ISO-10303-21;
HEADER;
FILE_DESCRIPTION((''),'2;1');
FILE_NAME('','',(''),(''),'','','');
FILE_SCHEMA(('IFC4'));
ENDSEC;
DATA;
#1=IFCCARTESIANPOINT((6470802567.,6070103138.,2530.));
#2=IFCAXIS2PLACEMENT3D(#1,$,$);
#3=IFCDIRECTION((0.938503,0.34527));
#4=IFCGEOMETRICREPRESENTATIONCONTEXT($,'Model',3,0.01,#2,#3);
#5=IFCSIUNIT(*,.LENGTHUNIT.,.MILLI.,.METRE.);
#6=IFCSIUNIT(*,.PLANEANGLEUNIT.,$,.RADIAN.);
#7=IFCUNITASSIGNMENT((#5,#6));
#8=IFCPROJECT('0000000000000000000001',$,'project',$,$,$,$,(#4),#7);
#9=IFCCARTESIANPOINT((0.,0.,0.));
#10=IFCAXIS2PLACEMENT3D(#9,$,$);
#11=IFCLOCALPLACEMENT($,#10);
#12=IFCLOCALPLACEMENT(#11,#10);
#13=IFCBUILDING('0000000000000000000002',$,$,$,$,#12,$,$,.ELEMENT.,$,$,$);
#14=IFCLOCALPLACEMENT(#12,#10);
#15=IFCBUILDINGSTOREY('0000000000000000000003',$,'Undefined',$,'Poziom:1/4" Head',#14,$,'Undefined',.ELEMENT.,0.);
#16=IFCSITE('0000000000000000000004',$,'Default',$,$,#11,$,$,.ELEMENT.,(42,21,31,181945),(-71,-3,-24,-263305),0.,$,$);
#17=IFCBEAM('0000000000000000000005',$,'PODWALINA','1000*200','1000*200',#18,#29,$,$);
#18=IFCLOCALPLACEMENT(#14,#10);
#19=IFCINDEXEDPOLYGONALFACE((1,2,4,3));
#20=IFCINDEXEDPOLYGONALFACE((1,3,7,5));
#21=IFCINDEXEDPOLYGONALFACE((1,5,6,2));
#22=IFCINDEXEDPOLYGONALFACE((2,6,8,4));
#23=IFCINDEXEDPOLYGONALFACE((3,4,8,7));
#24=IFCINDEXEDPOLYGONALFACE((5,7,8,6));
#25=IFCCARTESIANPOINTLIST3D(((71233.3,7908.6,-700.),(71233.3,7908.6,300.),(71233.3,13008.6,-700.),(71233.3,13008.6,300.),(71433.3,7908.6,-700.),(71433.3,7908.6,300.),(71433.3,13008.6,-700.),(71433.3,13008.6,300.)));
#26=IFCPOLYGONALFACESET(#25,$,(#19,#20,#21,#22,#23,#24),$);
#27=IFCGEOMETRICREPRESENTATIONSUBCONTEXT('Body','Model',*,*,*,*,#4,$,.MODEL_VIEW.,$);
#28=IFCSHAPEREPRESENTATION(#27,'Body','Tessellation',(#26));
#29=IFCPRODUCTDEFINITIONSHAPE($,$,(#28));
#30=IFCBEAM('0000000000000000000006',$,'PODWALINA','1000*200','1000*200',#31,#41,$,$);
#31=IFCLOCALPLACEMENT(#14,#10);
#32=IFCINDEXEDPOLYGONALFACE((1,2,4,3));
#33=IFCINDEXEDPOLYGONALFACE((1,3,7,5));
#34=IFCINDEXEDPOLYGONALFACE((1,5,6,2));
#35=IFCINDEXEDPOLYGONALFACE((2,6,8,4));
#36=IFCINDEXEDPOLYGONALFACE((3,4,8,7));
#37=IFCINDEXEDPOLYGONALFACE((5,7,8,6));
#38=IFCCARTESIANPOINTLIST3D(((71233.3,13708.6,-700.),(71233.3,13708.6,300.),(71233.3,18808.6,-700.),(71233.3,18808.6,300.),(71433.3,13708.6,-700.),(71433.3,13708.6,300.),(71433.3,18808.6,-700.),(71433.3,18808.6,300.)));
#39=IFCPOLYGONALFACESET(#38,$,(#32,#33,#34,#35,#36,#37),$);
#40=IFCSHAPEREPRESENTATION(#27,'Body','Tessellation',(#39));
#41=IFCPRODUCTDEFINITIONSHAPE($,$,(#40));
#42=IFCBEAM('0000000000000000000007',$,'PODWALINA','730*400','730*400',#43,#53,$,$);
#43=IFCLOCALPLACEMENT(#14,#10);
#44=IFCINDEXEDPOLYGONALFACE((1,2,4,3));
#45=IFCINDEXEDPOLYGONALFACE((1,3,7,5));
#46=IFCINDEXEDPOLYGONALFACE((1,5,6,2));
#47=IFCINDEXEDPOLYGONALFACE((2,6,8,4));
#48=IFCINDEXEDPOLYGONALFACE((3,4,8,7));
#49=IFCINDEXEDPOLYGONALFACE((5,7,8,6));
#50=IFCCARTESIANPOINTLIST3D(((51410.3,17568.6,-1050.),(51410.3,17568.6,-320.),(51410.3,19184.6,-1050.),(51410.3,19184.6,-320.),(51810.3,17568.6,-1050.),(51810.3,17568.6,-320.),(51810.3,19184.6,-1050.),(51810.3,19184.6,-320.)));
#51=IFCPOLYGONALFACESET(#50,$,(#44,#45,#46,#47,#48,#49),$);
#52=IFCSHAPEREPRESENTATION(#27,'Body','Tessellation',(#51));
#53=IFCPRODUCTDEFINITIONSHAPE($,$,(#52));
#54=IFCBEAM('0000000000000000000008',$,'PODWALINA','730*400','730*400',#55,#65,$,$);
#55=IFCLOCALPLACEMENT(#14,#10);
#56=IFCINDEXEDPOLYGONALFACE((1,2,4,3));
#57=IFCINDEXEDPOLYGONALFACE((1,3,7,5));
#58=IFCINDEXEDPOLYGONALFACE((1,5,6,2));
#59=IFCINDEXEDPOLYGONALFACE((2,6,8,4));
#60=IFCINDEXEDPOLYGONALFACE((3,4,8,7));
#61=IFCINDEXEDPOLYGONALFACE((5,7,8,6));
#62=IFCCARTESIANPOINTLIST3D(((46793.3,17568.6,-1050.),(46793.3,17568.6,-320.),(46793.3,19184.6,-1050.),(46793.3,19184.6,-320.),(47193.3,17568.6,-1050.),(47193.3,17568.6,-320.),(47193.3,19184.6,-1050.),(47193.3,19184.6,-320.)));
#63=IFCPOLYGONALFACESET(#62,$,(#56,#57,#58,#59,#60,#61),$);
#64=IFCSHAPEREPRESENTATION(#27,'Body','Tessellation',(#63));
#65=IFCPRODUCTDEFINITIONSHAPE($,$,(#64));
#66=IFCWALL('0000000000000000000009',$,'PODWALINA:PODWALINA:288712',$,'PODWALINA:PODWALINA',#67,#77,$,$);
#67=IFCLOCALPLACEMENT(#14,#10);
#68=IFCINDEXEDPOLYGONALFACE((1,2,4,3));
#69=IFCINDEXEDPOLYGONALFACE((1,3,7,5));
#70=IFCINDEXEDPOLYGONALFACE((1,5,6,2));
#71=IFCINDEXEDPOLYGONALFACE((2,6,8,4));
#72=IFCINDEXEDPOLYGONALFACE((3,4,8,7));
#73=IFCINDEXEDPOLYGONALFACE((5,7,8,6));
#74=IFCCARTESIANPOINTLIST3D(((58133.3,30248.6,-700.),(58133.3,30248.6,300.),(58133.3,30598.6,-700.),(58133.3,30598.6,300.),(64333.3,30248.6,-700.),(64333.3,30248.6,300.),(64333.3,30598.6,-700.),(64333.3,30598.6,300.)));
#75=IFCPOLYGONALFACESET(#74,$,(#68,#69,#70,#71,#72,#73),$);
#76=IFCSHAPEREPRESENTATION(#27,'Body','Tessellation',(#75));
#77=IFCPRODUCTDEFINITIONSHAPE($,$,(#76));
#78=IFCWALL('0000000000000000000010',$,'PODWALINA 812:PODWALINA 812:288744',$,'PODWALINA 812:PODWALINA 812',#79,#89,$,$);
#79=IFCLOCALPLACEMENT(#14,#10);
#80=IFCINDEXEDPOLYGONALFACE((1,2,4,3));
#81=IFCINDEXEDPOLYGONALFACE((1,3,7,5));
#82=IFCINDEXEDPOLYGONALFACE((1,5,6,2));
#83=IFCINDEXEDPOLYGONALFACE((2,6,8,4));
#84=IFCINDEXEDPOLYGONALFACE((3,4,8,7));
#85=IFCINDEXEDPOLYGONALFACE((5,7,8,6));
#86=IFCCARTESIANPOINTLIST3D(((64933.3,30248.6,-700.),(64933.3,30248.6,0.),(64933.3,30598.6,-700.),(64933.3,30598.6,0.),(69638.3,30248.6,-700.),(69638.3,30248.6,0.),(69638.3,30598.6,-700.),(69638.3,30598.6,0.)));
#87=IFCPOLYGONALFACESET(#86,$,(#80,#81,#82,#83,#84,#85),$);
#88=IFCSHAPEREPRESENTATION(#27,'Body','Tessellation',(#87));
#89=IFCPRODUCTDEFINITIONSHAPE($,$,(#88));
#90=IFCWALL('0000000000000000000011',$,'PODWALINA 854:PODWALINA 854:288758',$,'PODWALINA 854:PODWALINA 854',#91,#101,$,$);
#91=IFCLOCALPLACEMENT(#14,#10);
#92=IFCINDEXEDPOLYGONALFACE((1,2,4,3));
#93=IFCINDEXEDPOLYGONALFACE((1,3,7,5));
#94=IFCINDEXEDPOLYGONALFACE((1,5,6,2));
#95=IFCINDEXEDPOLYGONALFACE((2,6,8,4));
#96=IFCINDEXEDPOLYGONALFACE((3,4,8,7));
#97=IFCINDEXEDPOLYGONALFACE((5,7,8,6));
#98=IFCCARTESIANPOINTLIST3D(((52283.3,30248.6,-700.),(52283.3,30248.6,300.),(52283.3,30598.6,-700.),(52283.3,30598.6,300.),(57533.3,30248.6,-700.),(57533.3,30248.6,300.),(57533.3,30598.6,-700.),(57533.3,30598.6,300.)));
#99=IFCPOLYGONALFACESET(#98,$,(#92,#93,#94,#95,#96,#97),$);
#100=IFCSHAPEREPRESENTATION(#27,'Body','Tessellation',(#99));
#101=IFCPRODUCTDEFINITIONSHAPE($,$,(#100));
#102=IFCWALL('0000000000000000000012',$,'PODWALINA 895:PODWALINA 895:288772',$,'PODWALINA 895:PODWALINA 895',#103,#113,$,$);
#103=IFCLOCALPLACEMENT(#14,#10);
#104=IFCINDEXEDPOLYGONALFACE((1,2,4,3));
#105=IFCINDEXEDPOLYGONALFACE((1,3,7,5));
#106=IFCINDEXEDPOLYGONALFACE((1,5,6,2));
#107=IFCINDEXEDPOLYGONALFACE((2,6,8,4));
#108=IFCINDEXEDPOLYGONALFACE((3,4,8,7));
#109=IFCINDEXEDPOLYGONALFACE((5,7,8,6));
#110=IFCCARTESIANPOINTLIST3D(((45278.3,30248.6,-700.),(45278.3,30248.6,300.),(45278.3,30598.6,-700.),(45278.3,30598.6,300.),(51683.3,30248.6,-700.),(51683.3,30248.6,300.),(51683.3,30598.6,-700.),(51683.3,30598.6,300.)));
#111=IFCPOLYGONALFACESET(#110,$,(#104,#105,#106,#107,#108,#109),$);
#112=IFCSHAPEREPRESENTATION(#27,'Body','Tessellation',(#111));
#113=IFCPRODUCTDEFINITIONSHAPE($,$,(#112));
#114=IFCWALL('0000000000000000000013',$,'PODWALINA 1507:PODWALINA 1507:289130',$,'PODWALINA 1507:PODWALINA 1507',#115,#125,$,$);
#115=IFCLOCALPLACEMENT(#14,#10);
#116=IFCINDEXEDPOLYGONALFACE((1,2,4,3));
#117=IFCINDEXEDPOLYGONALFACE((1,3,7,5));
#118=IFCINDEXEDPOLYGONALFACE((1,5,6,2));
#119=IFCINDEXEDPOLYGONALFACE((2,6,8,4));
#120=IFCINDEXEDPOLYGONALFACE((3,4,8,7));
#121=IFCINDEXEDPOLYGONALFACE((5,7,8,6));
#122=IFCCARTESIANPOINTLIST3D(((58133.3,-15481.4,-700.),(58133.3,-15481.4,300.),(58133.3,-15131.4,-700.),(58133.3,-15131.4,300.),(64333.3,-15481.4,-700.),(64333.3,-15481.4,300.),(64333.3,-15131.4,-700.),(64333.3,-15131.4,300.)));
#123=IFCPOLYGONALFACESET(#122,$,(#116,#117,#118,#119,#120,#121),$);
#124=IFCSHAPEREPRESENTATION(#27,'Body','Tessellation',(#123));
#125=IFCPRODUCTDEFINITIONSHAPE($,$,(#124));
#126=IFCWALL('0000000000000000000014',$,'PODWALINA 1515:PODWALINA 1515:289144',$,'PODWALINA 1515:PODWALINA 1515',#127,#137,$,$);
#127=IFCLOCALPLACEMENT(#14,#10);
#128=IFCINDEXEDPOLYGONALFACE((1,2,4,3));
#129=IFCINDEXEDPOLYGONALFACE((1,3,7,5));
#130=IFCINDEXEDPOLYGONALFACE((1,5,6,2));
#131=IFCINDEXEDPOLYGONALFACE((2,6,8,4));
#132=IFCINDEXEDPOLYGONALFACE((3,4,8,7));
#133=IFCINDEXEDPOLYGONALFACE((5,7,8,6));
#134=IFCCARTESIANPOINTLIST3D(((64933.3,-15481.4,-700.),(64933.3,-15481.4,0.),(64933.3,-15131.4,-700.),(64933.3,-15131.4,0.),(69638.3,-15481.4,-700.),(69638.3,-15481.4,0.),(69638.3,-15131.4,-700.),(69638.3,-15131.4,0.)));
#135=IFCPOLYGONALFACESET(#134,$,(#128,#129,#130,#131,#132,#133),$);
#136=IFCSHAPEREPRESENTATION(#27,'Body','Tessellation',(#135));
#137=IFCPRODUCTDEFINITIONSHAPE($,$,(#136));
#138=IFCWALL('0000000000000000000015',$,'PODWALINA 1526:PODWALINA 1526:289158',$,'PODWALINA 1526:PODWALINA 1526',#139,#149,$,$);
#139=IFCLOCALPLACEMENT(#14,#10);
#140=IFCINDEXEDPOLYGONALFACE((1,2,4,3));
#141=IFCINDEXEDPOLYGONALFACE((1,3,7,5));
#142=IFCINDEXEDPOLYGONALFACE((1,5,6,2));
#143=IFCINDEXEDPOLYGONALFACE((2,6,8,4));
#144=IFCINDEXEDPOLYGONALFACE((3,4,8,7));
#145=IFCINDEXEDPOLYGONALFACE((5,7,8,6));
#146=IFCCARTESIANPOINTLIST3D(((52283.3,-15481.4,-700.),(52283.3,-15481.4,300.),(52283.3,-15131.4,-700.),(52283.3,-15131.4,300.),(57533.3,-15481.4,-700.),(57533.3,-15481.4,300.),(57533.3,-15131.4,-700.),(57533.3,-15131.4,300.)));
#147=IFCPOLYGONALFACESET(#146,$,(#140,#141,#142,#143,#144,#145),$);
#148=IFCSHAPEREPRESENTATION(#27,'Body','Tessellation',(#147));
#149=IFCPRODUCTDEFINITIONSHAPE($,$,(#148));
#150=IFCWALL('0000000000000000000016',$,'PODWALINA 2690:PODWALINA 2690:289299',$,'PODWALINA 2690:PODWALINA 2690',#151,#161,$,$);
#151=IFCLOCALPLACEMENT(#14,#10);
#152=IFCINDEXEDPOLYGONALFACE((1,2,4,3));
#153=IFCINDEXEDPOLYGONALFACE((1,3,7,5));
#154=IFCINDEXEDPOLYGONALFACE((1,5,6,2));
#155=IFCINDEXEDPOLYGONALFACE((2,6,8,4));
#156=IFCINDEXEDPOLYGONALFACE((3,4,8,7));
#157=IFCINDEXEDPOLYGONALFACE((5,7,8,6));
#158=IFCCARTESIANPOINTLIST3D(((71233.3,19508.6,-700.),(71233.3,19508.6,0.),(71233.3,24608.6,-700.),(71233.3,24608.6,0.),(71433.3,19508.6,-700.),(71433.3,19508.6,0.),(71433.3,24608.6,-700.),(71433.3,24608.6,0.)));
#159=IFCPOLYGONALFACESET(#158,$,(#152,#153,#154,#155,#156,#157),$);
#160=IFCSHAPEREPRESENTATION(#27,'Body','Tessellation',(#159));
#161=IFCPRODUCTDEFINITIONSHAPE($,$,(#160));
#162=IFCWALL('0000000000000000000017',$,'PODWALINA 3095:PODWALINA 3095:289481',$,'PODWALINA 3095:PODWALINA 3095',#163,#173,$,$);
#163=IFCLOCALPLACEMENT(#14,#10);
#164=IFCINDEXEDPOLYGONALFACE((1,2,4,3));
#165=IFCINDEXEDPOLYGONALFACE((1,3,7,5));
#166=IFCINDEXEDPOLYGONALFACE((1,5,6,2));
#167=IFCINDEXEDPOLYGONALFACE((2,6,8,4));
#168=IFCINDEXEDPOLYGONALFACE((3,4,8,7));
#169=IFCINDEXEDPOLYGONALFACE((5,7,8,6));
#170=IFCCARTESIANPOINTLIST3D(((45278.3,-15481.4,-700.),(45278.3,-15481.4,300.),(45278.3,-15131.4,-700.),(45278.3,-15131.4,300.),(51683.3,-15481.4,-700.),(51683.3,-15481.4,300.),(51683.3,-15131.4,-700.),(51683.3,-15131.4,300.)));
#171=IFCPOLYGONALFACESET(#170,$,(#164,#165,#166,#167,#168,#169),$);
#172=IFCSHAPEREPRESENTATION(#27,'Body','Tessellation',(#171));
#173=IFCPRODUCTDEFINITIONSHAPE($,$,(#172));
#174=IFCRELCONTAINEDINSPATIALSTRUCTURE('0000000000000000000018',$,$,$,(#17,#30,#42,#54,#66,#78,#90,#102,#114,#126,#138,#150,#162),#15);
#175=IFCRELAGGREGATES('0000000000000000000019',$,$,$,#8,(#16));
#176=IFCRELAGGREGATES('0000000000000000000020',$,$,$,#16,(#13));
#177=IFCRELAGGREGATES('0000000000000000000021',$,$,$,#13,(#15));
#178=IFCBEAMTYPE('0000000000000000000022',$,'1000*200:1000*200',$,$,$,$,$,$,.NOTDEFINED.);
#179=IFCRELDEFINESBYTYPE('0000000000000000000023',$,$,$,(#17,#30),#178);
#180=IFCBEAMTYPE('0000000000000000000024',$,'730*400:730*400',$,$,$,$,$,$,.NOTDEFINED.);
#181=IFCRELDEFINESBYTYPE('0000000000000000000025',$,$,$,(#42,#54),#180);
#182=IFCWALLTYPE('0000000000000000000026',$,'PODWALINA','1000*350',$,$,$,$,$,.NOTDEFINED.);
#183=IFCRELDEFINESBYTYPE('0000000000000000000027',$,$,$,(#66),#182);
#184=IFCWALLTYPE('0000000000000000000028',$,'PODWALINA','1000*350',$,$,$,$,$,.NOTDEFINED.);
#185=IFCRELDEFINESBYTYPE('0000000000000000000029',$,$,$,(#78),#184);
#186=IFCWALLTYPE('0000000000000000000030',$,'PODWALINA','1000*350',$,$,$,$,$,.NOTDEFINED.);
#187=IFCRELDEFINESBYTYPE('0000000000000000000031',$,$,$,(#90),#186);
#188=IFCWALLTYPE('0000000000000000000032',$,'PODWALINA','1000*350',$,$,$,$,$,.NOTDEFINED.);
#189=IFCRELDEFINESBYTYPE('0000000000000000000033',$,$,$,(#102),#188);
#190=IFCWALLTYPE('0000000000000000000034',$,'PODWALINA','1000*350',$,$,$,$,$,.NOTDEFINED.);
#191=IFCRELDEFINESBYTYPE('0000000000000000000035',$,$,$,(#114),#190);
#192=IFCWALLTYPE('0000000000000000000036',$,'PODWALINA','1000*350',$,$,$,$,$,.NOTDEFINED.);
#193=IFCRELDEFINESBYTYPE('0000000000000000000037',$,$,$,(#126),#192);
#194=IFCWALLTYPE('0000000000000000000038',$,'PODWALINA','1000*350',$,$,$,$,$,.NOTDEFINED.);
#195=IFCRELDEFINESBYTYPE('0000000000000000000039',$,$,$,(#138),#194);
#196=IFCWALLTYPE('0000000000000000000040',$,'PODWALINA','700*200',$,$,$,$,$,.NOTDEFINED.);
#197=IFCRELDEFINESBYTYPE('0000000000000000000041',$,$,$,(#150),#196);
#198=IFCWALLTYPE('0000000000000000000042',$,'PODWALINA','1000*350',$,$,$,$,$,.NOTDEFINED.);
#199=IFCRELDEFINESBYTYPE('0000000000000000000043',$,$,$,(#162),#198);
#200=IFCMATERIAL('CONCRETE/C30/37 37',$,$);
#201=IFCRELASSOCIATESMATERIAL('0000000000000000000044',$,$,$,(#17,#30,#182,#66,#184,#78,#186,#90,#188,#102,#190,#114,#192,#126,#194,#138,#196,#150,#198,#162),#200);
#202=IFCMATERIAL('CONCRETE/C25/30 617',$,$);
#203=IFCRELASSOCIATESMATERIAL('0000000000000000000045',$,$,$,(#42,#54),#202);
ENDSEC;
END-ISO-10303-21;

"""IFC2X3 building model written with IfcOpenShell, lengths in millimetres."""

from ifc_helpers import new_model, si_unit, direction, frame, frame_2d, origin, origin_2d_with_axis, place, context, subcontext, project, spatial, rectangle, extrude, material, type_object, element, save


model = new_model("IFC2X3")

# Units and contexts
model_context = context("Model", 3, precision=0.01, world=frame((6470802567.0, 6070103138.0, 2530.0)), true_north=direction((0.938503, 0.34527)))
body_context = subcontext(model_context, "Body", "Model", "MODEL_VIEW")
ifc_project = project(units=[si_unit("LENGTHUNIT", "METRE", prefix="MILLI"), si_unit("PLANEANGLEUNIT", "RADIAN")], contexts=[model_context])

# Site, building, storey
site_placement = place(None, origin())
site = spatial("IfcSite", under=ifc_project, at=site_placement, Name="Default", CompositionType="ELEMENT", RefLatitude=(42, 21, 31, 181945), RefLongitude=(-71, -3, -24, -263305), RefElevation=0.0)
building_placement = place(site_placement, origin())
building = spatial("IfcBuilding", under=site, at=building_placement, CompositionType="ELEMENT")
storey_placement = place(building_placement, origin())
storey = spatial("IfcBuildingStorey", under=building, at=storey_placement, Name="Undefined", ObjectType="Poziom:1/4\" Head", LongName="Undefined", CompositionType="ELEMENT", Elevation=0.0)

# Beams
ifc_material_1 = material(Name="CONCRETE/C30/37 37")
beam_type_1 = type_object("IfcBeamType", Name="1000*200:1000*200", PredefinedType="NOTDEFINED")
beam_1_placement = place(storey_placement, origin())
element("IfcBeam", 1, at=beam_1_placement, inside=storey, type_object=beam_type_1, material=ifc_material_1, Name="PODWALINA", Description="1000*200", ObjectType="1000*200", context=body_context, shape_type="SweptSolid", body=[
    extrude(rectangle(XDim=1000.0, YDim=5100.0, at=frame_2d((0.0, 0.0), x_axis=(0.0, 1.0))), frame((71233.3, 10458.6, -200.0), z_axis=(1.0, 0.0, 0.0), x_axis=(0.0, -1.0, 0.0)), (0.0, 0.0, 1.0), 200.0),
])
beam_2_placement = place(storey_placement, origin())
element("IfcBeam", 2, at=beam_2_placement, inside=storey, type_object=beam_type_1, material=ifc_material_1, Name="PODWALINA", Description="1000*200", ObjectType="1000*200", context=body_context, shape_type="SweptSolid", body=[
    extrude(rectangle(XDim=1000.0, YDim=5100.0, at=frame_2d((0.0, 0.0), x_axis=(0.0, 1.0))), frame((71233.3, 16258.6, -200.0), z_axis=(1.0, 0.0, 0.0), x_axis=(0.0, -1.0, 0.0)), (0.0, 0.0, 1.0), 200.0),
])
ifc_material_2 = material(Name="CONCRETE/C25/30 617")
beam_type_2 = type_object("IfcBeamType", Name="730*400:730*400", PredefinedType="NOTDEFINED")
beam_3_placement = place(storey_placement, origin())
element("IfcBeam", 3, at=beam_3_placement, inside=storey, type_object=beam_type_2, material=ifc_material_2, Name="PODWALINA", Description="730*400", ObjectType="730*400", context=body_context, shape_type="SweptSolid", body=[
    extrude(rectangle(XDim=730.0, YDim=1616.0, at=frame_2d((0.0, 0.0), x_axis=(0.0, 1.0))), frame((51410.3, 18376.6, -685.0), z_axis=(1.0, 0.0, 0.0), x_axis=(0.0, 1.0, 0.0)), (0.0, 0.0, 1.0), 400.0),
])
beam_4_placement = place(storey_placement, origin())
element("IfcBeam", 4, at=beam_4_placement, inside=storey, type_object=beam_type_2, material=ifc_material_2, Name="PODWALINA", Description="730*400", ObjectType="730*400", context=body_context, shape_type="SweptSolid", body=[
    extrude(rectangle(XDim=730.0, YDim=1616.0, at=frame_2d((0.0, 0.0), x_axis=(0.0, 1.0))), frame((46793.3, 18376.6, -685.0), z_axis=(1.0, 0.0, 0.0), x_axis=(0.0, 1.0, 0.0)), (0.0, 0.0, 1.0), 400.0),
])

# Walls
wall_type_1 = type_object("IfcWallType", Name="PODWALINA", Description="1000*350", PredefinedType="NOTDEFINED", material=ifc_material_1)
wall_1_placement = place(storey_placement, frame((58133.3, 30248.6, -700.0)))
element("IfcWall", 5, at=wall_1_placement, inside=storey, type_object=wall_type_1, material=ifc_material_1, Name="PODWALINA:PODWALINA:288712", ObjectType="PODWALINA:PODWALINA", context=body_context, shape_type="SweptSolid", body=[
    extrude(rectangle(XDim=350.0, YDim=6200.0, at=frame_2d((0.0, 0.0), x_axis=(1.0, 0.0))), frame((3100.0, 175.0, 0.0), z_axis=(0.0, 0.0, 1.0), x_axis=(0.0, -1.0, 0.0)), (0.0, 0.0, 1.0), 1000.0),
])
wall_type_2 = type_object("IfcWallType", Name="PODWALINA", Description="1000*350", PredefinedType="NOTDEFINED", material=ifc_material_1)
wall_2_placement = place(storey_placement, frame((64933.3, 30248.6, -700.0)))
element("IfcWall", 6, at=wall_2_placement, inside=storey, type_object=wall_type_2, material=ifc_material_1, Name="PODWALINA 812:PODWALINA 812:288744", ObjectType="PODWALINA 812:PODWALINA 812", context=body_context, shape_type="SweptSolid", body=[
    extrude(rectangle(XDim=350.0, YDim=4705.0, at=frame_2d((0.0, 0.0), x_axis=(1.0, 0.0))), frame((2352.5, 175.0, 0.0), z_axis=(0.0, 0.0, 1.0), x_axis=(0.0, -1.0, 0.0)), (0.0, 0.0, 1.0), 700.0),
])
wall_type_3 = type_object("IfcWallType", Name="PODWALINA", Description="1000*350", PredefinedType="NOTDEFINED", material=ifc_material_1)
wall_3_placement = place(storey_placement, frame((52283.3, 30248.6, -700.0)))
element("IfcWall", 7, at=wall_3_placement, inside=storey, type_object=wall_type_3, material=ifc_material_1, Name="PODWALINA 854:PODWALINA 854:288758", ObjectType="PODWALINA 854:PODWALINA 854", context=body_context, shape_type="SweptSolid", body=[
    extrude(rectangle(XDim=350.0, YDim=5250.0, at=frame_2d((0.0, 0.0), x_axis=(1.0, 0.0))), frame((2625.0, 175.0, 0.0), z_axis=(0.0, 0.0, 1.0), x_axis=(0.0, -1.0, 0.0)), (0.0, 0.0, 1.0), 1000.0),
])
wall_type_4 = type_object("IfcWallType", Name="PODWALINA", Description="1000*350", PredefinedType="NOTDEFINED", material=ifc_material_1)
wall_4_placement = place(storey_placement, frame((45278.3, 30248.6, -700.0)))
element("IfcWall", 8, at=wall_4_placement, inside=storey, type_object=wall_type_4, material=ifc_material_1, Name="PODWALINA 895:PODWALINA 895:288772", ObjectType="PODWALINA 895:PODWALINA 895", context=body_context, shape_type="SweptSolid", body=[
    extrude(rectangle(XDim=350.0, YDim=6405.0, at=origin_2d_with_axis()), frame((3202.5, 175.0, 0.0), z_axis=(0.0, 0.0, 1.0), x_axis=(0.0, -1.0, 0.0)), (0.0, 0.0, 1.0), 1000.0),
])
wall_type_5 = type_object("IfcWallType", Name="PODWALINA", Description="1000*350", PredefinedType="NOTDEFINED", material=ifc_material_1)
wall_5_placement = place(storey_placement, frame((58133.3, -15481.4, -700.0)))
element("IfcWall", 9, at=wall_5_placement, inside=storey, type_object=wall_type_5, material=ifc_material_1, Name="PODWALINA 1507:PODWALINA 1507:289130", ObjectType="PODWALINA 1507:PODWALINA 1507", context=body_context, shape_type="SweptSolid", body=[
    extrude(rectangle(XDim=350.0, YDim=6200.0, at=frame_2d((0.0, 0.0), x_axis=(1.0, 0.0))), frame((3100.0, 175.0, 0.0), z_axis=(0.0, 0.0, 1.0), x_axis=(0.0, -1.0, 0.0)), (0.0, 0.0, 1.0), 1000.0),
])
wall_type_6 = type_object("IfcWallType", Name="PODWALINA", Description="1000*350", PredefinedType="NOTDEFINED", material=ifc_material_1)
wall_6_placement = place(storey_placement, frame((64933.3, -15481.4, -700.0)))
element("IfcWall", 10, at=wall_6_placement, inside=storey, type_object=wall_type_6, material=ifc_material_1, Name="PODWALINA 1515:PODWALINA 1515:289144", ObjectType="PODWALINA 1515:PODWALINA 1515", context=body_context, shape_type="SweptSolid", body=[
    extrude(rectangle(XDim=350.0, YDim=4705.0, at=frame_2d((0.0, 0.0), x_axis=(1.0, 0.0))), frame((2352.5, 175.0, 0.0), z_axis=(0.0, 0.0, 1.0), x_axis=(0.0, -1.0, 0.0)), (0.0, 0.0, 1.0), 700.0),
])
wall_type_7 = type_object("IfcWallType", Name="PODWALINA", Description="1000*350", PredefinedType="NOTDEFINED", material=ifc_material_1)
wall_7_placement = place(storey_placement, frame((52283.3, -15481.4, -700.0)))
element("IfcWall", 11, at=wall_7_placement, inside=storey, type_object=wall_type_7, material=ifc_material_1, Name="PODWALINA 1526:PODWALINA 1526:289158", ObjectType="PODWALINA 1526:PODWALINA 1526", context=body_context, shape_type="SweptSolid", body=[
    extrude(rectangle(XDim=350.0, YDim=5250.0, at=frame_2d((0.0, 0.0), x_axis=(1.0, 0.0))), frame((2625.0, 175.0, 0.0), z_axis=(0.0, 0.0, 1.0), x_axis=(0.0, -1.0, 0.0)), (0.0, 0.0, 1.0), 1000.0),
])
wall_type_8 = type_object("IfcWallType", Name="PODWALINA", Description="700*200", PredefinedType="NOTDEFINED", material=ifc_material_1)
wall_8_placement = place(storey_placement, frame((71233.3, 19508.6, -700.0), z_axis=(0.0, 0.0, 1.0), x_axis=(0.0, 1.0, 0.0)))
element("IfcWall", 12, at=wall_8_placement, inside=storey, type_object=wall_type_8, material=ifc_material_1, Name="PODWALINA 2690:PODWALINA 2690:289299", ObjectType="PODWALINA 2690:PODWALINA 2690", context=body_context, shape_type="SweptSolid", body=[
    extrude(rectangle(XDim=200.0, YDim=5100.0, at=frame_2d((0.0, 0.0), x_axis=(1.0, 0.0))), frame((2550.0, -100.0, 0.0), z_axis=(0.0, 0.0, 1.0), x_axis=(0.0, -1.0, 0.0)), (0.0, 0.0, 1.0), 700.0),
])
wall_type_9 = type_object("IfcWallType", Name="PODWALINA", Description="1000*350", PredefinedType="NOTDEFINED", material=ifc_material_1)
wall_9_placement = place(storey_placement, frame((45278.3, -15481.4, -700.0)))
element("IfcWall", 13, at=wall_9_placement, inside=storey, type_object=wall_type_9, material=ifc_material_1, Name="PODWALINA 3095:PODWALINA 3095:289481", ObjectType="PODWALINA 3095:PODWALINA 3095", context=body_context, shape_type="SweptSolid", body=[
    extrude(rectangle(XDim=350.0, YDim=6405.0, at=frame_2d((0.0, 0.0), x_axis=(1.0, 0.0))), frame((3202.5, 175.0, 0.0), z_axis=(0.0, 0.0, 1.0), x_axis=(0.0, -1.0, 0.0)), (0.0, 0.0, 1.0), 1000.0),
])

save(model, "model.ifc")
